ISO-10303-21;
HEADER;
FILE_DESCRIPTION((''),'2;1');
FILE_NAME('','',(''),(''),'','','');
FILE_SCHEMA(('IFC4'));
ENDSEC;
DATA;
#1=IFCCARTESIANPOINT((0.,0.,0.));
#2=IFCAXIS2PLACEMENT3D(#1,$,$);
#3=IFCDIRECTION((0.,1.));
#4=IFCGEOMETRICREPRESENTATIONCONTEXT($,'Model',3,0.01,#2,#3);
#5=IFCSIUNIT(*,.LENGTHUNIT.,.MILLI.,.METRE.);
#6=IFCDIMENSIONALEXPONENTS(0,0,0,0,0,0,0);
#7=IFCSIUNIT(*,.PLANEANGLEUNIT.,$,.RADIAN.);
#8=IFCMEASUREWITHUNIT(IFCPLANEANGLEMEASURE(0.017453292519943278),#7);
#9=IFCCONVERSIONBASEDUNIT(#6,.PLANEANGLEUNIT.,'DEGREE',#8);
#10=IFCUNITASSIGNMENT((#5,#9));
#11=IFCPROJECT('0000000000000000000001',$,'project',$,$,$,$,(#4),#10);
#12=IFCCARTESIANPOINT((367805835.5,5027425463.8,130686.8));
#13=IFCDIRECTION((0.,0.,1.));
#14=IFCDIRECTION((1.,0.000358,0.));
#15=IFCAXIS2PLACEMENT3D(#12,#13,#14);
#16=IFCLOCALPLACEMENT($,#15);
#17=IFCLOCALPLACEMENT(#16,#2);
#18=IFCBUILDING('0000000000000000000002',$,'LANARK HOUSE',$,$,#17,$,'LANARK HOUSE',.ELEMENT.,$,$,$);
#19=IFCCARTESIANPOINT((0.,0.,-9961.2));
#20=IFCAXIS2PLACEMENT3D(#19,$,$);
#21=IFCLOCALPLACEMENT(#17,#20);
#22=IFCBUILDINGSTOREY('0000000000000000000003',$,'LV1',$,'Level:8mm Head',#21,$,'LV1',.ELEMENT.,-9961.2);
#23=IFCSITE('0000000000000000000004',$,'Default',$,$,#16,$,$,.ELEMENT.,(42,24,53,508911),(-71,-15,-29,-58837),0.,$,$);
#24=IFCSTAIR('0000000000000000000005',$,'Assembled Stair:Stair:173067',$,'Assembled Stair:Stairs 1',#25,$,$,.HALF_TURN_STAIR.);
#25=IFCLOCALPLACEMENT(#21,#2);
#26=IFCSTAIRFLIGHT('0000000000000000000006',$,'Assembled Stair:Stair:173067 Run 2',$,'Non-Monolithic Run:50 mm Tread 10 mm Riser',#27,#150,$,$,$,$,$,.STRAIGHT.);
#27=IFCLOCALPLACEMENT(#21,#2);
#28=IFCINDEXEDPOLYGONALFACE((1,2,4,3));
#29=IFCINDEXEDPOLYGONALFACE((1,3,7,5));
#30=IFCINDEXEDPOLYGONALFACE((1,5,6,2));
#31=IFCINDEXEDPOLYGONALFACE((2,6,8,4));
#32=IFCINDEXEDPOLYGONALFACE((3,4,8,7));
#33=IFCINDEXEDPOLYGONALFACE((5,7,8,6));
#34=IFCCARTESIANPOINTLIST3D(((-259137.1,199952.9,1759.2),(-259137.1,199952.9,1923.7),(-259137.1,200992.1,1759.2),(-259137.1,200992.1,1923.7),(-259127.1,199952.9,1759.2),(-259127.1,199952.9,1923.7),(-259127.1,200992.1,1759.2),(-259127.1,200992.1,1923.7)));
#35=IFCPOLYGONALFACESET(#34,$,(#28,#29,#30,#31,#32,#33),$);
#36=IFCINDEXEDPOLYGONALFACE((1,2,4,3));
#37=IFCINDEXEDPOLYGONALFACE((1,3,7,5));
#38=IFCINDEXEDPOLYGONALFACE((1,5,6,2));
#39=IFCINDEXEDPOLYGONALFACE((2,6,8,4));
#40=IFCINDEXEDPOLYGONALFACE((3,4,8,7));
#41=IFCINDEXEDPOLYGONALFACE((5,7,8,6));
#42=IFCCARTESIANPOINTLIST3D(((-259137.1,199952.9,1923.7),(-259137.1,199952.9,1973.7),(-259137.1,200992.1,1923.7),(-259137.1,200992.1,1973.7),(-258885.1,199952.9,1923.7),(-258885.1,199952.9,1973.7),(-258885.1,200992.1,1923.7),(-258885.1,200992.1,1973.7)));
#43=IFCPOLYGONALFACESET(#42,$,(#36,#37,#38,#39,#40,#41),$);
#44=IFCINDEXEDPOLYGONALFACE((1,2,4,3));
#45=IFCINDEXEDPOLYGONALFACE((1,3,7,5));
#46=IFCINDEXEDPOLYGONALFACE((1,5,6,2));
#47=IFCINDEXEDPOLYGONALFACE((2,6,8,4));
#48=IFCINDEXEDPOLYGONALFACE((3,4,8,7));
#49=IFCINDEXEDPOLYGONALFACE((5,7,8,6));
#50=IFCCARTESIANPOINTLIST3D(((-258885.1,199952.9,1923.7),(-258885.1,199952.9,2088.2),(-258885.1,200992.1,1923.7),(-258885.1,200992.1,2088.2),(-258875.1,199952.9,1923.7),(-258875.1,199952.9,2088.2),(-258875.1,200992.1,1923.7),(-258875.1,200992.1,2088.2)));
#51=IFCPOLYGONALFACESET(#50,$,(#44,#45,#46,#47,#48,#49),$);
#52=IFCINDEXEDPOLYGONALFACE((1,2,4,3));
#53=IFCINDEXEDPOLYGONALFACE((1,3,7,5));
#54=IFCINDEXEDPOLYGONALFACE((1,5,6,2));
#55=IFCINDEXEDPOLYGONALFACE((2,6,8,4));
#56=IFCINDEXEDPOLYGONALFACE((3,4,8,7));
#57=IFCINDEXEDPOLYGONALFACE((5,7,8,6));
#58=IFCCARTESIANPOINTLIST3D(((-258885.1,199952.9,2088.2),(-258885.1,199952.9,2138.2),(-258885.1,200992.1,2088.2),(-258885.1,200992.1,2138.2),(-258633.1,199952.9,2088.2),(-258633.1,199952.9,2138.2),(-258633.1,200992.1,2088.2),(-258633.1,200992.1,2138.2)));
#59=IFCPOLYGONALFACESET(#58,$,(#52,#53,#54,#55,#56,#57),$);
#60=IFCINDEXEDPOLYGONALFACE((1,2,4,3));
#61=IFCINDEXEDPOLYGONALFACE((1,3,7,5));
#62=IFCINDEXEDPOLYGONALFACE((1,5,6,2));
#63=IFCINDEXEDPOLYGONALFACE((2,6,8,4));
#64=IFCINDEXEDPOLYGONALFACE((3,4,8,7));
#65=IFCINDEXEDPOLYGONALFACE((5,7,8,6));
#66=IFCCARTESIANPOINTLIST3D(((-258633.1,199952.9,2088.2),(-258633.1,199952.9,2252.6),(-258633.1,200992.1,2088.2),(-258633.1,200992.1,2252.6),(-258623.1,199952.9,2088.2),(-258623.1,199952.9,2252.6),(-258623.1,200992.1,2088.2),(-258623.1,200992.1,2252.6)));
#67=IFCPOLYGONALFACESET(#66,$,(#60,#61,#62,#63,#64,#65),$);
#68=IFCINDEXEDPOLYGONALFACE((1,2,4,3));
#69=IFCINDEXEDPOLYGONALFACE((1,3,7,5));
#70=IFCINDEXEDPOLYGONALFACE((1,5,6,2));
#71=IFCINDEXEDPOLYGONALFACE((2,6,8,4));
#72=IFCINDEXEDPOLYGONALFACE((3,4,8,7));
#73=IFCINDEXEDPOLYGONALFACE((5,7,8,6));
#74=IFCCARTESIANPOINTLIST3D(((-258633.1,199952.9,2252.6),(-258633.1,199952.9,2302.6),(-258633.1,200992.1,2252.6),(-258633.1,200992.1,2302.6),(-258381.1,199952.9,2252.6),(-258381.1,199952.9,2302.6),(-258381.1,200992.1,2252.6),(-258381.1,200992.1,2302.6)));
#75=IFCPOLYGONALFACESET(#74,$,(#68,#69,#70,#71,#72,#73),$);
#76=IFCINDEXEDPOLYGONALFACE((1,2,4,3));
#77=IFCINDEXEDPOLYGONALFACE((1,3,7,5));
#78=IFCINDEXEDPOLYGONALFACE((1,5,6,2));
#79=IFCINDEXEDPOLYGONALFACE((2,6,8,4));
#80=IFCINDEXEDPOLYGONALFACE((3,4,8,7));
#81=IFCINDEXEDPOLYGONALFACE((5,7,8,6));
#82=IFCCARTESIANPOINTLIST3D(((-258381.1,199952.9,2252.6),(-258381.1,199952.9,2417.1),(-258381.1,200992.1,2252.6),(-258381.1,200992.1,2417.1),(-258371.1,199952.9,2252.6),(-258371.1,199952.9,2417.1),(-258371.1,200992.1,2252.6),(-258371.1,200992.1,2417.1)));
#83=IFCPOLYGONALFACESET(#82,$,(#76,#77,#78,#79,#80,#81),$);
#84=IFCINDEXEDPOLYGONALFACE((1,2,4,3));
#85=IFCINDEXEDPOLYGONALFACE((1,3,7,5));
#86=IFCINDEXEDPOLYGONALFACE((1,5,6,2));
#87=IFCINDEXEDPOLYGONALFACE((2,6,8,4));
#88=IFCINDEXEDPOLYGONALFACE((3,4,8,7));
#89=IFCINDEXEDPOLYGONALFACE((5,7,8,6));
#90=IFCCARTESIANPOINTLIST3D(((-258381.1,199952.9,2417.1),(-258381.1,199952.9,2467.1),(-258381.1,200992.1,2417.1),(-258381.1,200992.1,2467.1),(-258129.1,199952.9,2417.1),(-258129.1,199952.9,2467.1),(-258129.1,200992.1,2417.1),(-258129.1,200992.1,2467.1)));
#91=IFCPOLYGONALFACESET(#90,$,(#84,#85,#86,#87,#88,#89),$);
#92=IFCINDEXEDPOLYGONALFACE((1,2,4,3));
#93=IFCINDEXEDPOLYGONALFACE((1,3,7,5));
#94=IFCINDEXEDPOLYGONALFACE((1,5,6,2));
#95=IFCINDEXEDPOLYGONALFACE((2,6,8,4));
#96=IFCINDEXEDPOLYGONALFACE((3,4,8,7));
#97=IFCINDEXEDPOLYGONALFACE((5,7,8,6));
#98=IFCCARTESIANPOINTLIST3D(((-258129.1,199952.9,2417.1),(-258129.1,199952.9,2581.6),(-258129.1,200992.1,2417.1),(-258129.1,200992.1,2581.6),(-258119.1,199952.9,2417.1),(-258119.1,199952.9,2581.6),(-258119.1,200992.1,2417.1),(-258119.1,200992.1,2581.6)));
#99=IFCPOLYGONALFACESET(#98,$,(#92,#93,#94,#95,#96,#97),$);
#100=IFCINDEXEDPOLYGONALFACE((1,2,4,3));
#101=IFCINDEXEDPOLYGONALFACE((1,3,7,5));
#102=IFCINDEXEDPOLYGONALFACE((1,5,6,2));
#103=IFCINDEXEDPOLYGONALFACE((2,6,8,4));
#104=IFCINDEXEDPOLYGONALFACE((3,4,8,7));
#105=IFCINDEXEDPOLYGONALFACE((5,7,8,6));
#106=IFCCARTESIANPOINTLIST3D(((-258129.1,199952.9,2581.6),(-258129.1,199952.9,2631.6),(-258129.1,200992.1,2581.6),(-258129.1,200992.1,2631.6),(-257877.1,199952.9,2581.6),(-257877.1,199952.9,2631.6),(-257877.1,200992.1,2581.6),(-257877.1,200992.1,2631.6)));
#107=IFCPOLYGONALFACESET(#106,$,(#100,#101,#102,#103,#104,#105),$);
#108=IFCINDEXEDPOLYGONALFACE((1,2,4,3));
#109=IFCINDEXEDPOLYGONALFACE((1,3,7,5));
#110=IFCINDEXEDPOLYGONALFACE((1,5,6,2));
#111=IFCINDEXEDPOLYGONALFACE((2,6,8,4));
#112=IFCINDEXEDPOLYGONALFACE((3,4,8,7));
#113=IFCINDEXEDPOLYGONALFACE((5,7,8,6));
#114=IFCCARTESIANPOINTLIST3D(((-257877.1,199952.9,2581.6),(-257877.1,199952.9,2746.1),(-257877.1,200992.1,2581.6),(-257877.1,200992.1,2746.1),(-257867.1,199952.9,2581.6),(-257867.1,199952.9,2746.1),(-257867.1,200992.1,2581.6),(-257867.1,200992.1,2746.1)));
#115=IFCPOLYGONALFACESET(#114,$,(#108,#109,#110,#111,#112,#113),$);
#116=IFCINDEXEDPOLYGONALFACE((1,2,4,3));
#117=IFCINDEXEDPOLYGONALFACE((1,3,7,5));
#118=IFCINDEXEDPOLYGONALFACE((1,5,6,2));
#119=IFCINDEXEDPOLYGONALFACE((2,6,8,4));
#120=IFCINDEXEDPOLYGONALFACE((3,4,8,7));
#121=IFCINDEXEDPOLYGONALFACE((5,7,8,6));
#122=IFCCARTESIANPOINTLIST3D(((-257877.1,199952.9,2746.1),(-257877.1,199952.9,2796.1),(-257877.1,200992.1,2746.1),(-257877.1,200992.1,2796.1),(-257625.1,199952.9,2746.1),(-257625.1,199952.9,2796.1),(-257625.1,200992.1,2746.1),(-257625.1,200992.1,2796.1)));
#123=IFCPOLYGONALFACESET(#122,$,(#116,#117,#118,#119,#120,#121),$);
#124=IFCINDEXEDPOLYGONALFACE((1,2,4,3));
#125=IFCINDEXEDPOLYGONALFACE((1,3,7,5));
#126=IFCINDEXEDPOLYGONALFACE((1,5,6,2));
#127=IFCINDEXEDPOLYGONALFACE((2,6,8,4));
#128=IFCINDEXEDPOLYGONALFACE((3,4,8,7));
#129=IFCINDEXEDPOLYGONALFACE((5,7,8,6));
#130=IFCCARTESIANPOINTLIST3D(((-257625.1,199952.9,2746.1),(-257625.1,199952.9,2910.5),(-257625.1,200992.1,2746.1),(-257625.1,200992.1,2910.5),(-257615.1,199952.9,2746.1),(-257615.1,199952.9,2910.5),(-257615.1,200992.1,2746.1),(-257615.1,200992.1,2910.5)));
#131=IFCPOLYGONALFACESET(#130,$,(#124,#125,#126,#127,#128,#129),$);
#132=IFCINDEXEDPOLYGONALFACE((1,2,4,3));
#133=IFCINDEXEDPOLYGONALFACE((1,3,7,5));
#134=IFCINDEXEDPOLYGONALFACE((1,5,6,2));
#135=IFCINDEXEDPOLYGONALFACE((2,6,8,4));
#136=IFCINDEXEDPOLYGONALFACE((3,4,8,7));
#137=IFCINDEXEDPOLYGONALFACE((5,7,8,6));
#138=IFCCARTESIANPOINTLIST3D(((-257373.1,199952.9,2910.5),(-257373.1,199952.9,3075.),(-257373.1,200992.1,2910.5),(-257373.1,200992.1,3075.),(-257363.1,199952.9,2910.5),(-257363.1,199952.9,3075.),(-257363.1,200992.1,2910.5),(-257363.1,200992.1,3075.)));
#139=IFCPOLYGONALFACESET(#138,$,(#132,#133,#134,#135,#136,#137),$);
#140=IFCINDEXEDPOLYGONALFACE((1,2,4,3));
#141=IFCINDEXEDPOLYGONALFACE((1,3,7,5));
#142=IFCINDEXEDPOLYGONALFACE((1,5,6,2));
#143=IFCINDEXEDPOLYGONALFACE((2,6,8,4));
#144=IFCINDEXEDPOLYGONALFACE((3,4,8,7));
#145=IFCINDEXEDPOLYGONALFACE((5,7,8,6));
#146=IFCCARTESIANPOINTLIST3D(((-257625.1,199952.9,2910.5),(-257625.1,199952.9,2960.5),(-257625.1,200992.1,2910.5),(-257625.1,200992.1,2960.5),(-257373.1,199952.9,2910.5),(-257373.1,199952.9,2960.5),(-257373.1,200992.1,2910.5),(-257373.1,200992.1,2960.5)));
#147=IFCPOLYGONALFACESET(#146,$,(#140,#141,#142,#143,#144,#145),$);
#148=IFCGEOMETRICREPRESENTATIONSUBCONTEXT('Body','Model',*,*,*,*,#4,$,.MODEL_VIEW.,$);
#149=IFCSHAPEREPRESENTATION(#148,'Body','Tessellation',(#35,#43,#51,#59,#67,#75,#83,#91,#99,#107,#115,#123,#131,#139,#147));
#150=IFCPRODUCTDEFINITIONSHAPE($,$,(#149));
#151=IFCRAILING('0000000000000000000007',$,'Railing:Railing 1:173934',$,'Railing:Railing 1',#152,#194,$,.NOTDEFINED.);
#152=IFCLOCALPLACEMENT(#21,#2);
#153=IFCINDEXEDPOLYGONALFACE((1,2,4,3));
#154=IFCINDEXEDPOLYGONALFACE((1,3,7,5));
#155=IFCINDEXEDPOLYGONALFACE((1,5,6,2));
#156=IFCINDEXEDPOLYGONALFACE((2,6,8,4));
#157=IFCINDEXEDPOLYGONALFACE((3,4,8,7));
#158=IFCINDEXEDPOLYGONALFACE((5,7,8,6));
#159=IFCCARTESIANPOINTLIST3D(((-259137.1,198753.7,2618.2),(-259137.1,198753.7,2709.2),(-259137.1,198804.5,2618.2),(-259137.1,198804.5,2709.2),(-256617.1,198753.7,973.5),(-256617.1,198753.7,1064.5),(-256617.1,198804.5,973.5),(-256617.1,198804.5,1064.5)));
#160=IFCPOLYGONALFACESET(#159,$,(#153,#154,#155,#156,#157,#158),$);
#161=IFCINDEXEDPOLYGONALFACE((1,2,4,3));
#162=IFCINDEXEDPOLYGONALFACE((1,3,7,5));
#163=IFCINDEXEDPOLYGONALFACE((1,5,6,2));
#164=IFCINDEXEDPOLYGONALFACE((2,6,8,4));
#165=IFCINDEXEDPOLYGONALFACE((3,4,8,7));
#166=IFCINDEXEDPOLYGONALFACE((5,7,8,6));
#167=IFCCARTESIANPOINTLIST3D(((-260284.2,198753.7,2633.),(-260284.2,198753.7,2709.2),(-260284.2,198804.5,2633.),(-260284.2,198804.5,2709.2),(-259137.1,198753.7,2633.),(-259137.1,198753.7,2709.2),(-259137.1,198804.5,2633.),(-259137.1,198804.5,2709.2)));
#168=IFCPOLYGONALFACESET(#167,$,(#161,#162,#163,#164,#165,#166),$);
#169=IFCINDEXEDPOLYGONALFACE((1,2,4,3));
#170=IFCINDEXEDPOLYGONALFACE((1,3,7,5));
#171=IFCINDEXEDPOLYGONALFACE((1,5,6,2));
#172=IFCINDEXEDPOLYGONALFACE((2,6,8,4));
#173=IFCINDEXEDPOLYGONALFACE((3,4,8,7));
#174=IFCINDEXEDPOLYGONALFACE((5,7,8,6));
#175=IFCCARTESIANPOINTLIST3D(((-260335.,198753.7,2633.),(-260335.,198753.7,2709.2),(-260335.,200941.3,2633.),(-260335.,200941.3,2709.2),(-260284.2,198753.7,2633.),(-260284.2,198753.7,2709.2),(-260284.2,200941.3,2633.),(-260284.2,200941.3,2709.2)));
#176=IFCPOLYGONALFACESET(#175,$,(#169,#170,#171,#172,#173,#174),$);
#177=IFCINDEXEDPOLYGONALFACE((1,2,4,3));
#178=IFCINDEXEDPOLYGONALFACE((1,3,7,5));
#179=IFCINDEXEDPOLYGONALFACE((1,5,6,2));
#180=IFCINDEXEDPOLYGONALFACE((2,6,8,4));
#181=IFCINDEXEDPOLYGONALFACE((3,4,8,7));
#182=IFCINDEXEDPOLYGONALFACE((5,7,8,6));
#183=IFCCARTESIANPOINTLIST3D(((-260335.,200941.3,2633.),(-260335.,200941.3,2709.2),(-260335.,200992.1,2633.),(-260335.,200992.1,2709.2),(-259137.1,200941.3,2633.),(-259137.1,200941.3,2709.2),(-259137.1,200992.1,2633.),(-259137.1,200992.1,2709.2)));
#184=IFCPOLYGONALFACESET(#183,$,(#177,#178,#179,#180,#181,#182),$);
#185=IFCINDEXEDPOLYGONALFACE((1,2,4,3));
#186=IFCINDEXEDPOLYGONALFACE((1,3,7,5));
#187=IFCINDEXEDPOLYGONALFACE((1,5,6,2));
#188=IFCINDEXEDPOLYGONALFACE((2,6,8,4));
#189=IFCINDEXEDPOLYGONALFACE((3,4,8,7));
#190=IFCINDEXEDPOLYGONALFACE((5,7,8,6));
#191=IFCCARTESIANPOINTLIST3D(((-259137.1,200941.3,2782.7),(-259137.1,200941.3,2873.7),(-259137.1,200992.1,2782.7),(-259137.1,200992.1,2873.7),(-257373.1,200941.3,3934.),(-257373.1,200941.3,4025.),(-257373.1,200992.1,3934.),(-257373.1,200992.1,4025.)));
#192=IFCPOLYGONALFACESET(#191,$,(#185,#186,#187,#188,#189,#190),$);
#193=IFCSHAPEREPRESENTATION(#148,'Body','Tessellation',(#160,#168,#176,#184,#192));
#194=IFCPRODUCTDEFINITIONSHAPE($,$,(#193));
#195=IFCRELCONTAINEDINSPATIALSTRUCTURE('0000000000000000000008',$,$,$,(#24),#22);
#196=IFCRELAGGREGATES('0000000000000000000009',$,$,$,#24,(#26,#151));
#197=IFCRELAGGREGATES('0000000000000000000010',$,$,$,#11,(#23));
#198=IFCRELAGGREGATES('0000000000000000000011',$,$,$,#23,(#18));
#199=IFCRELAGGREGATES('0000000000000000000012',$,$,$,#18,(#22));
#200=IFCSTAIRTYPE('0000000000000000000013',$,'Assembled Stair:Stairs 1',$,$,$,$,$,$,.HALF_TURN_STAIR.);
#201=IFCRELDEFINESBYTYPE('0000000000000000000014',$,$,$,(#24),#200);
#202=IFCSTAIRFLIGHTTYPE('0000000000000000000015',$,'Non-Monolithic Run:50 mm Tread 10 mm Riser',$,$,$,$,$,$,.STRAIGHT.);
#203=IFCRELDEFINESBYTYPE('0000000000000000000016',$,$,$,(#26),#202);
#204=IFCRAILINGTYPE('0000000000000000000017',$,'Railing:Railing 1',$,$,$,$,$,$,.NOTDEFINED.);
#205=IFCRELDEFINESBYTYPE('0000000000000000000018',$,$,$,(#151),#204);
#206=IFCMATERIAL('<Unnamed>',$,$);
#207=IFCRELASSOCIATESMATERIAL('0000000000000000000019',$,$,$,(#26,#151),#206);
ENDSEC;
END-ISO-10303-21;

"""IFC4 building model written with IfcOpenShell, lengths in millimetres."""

from ifc_helpers import new_model, entity, si_unit, converted_unit, direction, frame, origin, place, context, subcontext, project, spatial, indexed_curve, outline, extrude, material, type_object, element, aggregate, save


model = new_model("IFC4")

# Units and contexts
model_context = context("Model", 3, precision=0.01, world=origin(), true_north=direction((0.0, 1.0)))
body_context = subcontext(model_context, "Body", "Model", "MODEL_VIEW")
ifc_project = project(units=[si_unit("LENGTHUNIT", "METRE", prefix="MILLI"), converted_unit("PLANEANGLEUNIT", "DEGREE", entity("IfcPlaneAngleMeasure", 0.017453292519943278), si_unit("PLANEANGLEUNIT", "RADIAN"), dimensions=[0, 0, 0, 0, 0, 0, 0])], contexts=[model_context])

# Site, building, storey
site_placement = place(None, frame((367805835.5, 5027425463.8, 130686.8), z_axis=(0.0, 0.0, 1.0), x_axis=(1.0, 0.000358, 0.0)))
site = spatial("IfcSite", under=ifc_project, at=site_placement, Name="Default", CompositionType="ELEMENT", RefLatitude=(42, 24, 53, 508911), RefLongitude=(-71, -15, -29, -58837), RefElevation=0.0)
building_placement = place(site_placement, origin())
building = spatial("IfcBuilding", under=site, at=building_placement, Name="LANARK HOUSE", LongName="LANARK HOUSE", CompositionType="ELEMENT")
storey_placement = place(building_placement, frame((0.0, 0.0, -9961.2)))
storey = spatial("IfcBuildingStorey", under=building, at=storey_placement, Name="LV1", ObjectType="Level:8mm Head", LongName="LV1", CompositionType="ELEMENT", Elevation=-9961.2)

# Stair
stair_type = type_object("IfcStairType", Name="Assembled Stair:Stairs 1", PredefinedType="HALF_TURN_STAIR")
stair_placement = place(storey_placement, origin())
stair = element("IfcStair", 1, at=stair_placement, inside=storey, type_object=stair_type, Name="Assembled Stair:Stair:173067", ObjectType="Assembled Stair:Stairs 1", PredefinedType="HALF_TURN_STAIR")
ifc_material_1 = material(Name="<Unnamed>")

# Stair flight
stair_flight_type = type_object("IfcStairFlightType", Name="Non-Monolithic Run:50 mm Tread 10 mm Riser", PredefinedType="STRAIGHT")
stair_flight_1_placement = place(stair_placement, frame((-259137.1, 199952.9, 0.0)))
stair_flight_1 = element("IfcStairFlight", 2, at=stair_flight_1_placement, type_object=stair_flight_type, material=ifc_material_1, Name="Assembled Stair:Stair:173067 Run 2", ObjectType="Non-Monolithic Run:50 mm Tread 10 mm Riser", PredefinedType="STRAIGHT", context=body_context, shape_type="SweptSolid", body=[
    extrude(outline(indexed_curve([(-519.6, -5.0), (519.6, -5.0), (519.6, 5.0), (-519.6, 5.0), (-519.6, -5.0)], self_intersect=False)), frame((5.0, 519.6, 1759.2), z_axis=(0.0, 0.0, 1.0), x_axis=(0.0, 1.0, 0.0)), (0.0, 0.0, 1.0), 164.5),
    extrude(outline(indexed_curve([(-126.0, -519.6), (126.0, -519.6), (126.0, 519.6), (-126.0, 519.6), (-126.0, -519.6)], self_intersect=False)), frame((126.0, 519.6, 1923.7), z_axis=(0.0, 0.0, 1.0), x_axis=(-1.0, 0.0, 0.0)), (0.0, 0.0, 1.0), 50.0),
    extrude(outline(indexed_curve([(-519.6, -5.0), (519.6, -5.0), (519.6, 5.0), (-519.6, 5.0), (-519.6, -5.0)], self_intersect=False)), frame((257.0, 519.6, 1923.7), z_axis=(0.0, 0.0, 1.0), x_axis=(0.0, 1.0, 0.0)), (0.0, 0.0, 1.0), 164.5),
    extrude(outline(indexed_curve([(-126.0, -519.6), (126.0, -519.6), (126.0, 519.6), (-126.0, 519.6), (-126.0, -519.6)], self_intersect=False)), frame((378.0, 519.6, 2088.2), z_axis=(0.0, 0.0, 1.0), x_axis=(-1.0, 0.0, 0.0)), (0.0, 0.0, 1.0), 50.0),
    extrude(outline(indexed_curve([(-519.6, -5.0), (519.6, -5.0), (519.6, 5.0), (-519.6, 5.0), (-519.6, -5.0)], self_intersect=False)), frame((509.0, 519.6, 2088.2), z_axis=(0.0, 0.0, 1.0), x_axis=(0.0, 1.0, 0.0)), (0.0, 0.0, 1.0), 164.5),
    extrude(outline(indexed_curve([(-126.0, -519.6), (126.0, -519.6), (126.0, 519.6), (-126.0, 519.6), (-126.0, -519.6)], self_intersect=False)), frame((630.0, 519.6, 2252.6), z_axis=(0.0, 0.0, 1.0), x_axis=(-1.0, 0.0, 0.0)), (0.0, 0.0, 1.0), 50.0),
    extrude(outline(indexed_curve([(-519.6, -5.0), (519.6, -5.0), (519.6, 5.0), (-519.6, 5.0), (-519.6, -5.0)], self_intersect=False)), frame((761.0, 519.6, 2252.6), z_axis=(0.0, 0.0, 1.0), x_axis=(0.0, 1.0, 0.0)), (0.0, 0.0, 1.0), 164.5),
    extrude(outline(indexed_curve([(-126.0, -519.6), (126.0, -519.6), (126.0, 519.6), (-126.0, 519.6), (-126.0, -519.6)], self_intersect=False)), frame((882.0, 519.6, 2417.1), z_axis=(0.0, 0.0, 1.0), x_axis=(-1.0, 0.0, 0.0)), (0.0, 0.0, 1.0), 50.0),
    extrude(outline(indexed_curve([(-519.6, -5.0), (519.6, -5.0), (519.6, 5.0), (-519.6, 5.0), (-519.6, -5.0)], self_intersect=False)), frame((1013.0, 519.6, 2417.1), z_axis=(0.0, 0.0, 1.0), x_axis=(0.0, 1.0, 0.0)), (0.0, 0.0, 1.0), 164.5),
    extrude(outline(indexed_curve([(-126.0, -519.6), (126.0, -519.6), (126.0, 519.6), (-126.0, 519.6), (-126.0, -519.6)], self_intersect=False)), frame((1134.0, 519.6, 2581.6), z_axis=(0.0, 0.0, 1.0), x_axis=(-1.0, 0.0, 0.0)), (0.0, 0.0, 1.0), 50.0),
    extrude(outline(indexed_curve([(-519.6, -5.0), (519.6, -5.0), (519.6, 5.0), (-519.6, 5.0), (-519.6, -5.0)], self_intersect=False)), frame((1265.0, 519.6, 2581.6), z_axis=(0.0, 0.0, 1.0), x_axis=(0.0, 1.0, 0.0)), (0.0, 0.0, 1.0), 164.5),
    extrude(outline(indexed_curve([(-126.0, -519.6), (126.0, -519.6), (126.0, 519.6), (-126.0, 519.6), (-126.0, -519.6)], self_intersect=False)), frame((1386.0, 519.6, 2746.1), z_axis=(0.0, 0.0, 1.0), x_axis=(-1.0, 0.0, 0.0)), (0.0, 0.0, 1.0), 50.0),
    extrude(outline(indexed_curve([(-519.6, -5.0), (519.6, -5.0), (519.6, 5.0), (-519.6, 5.0), (-519.6, -5.0)], self_intersect=False)), frame((1517.0, 519.6, 2746.1), z_axis=(0.0, 0.0, 1.0), x_axis=(0.0, 1.0, 0.0)), (0.0, 0.0, 1.0), 164.5),
    extrude(outline(indexed_curve([(-519.6, -5.0), (519.6, -5.0), (519.6, 5.0), (-519.6, 5.0), (-519.6, -5.0)], self_intersect=False)), frame((1769.0, 519.6, 2910.5), z_axis=(0.0, 0.0, 1.0), x_axis=(0.0, 1.0, 0.0)), (0.0, 0.0, 1.0), 164.5),
    extrude(outline(indexed_curve([(-126.0, -519.6), (126.0, -519.6), (126.0, 519.6), (-126.0, 519.6), (-126.0, -519.6)], self_intersect=False)), frame((1638.0, 519.6, 2910.5), z_axis=(0.0, 0.0, 1.0), x_axis=(-1.0, 0.0, 0.0)), (0.0, 0.0, 1.0), 50.0),
])

# Railing
railing_type = type_object("IfcRailingType", Name="Railing:Railing 1", PredefinedType="NOTDEFINED")
railing_placement = place(stair_placement, frame((-260335.0, 198753.7, 973.5)))
railing = element("IfcRailing", 3, at=railing_placement, type_object=railing_type, material=ifc_material_1, Name="Railing:Railing 1:173934", ObjectType="Railing:Railing 1", PredefinedType="NOTDEFINED", context=body_context, shape_type="SweptSolid", body=[
    extrude(outline(indexed_curve([(-1529.5, -38.1), (1479.8, -38.1), (1529.5, 38.1), (-1479.8, 38.1), (-1529.5, -38.1)], self_intersect=False)), frame((2457.9, 0.0, 867.9), z_axis=(0.0, 1.0, 0.0), x_axis=(-0.837419, 0.0, 0.546561)), (0.0, 0.0, 1.0), 50.8),
    extrude(outline(indexed_curve([(-573.6, -25.4), (573.6, -25.4), (573.6, 25.4), (-573.6, 25.4), (-573.6, -25.4)], self_intersect=False)), frame((624.4, 25.4, 1659.5), z_axis=(0.0, 0.0, 1.0), x_axis=(-1.0, 0.0, 0.0)), (0.0, 0.0, 1.0), 76.2),
    extrude(outline(indexed_curve([(-1093.8, -25.4), (1093.8, -25.4), (1093.8, 25.4), (-1093.8, 25.4), (-1093.8, -25.4)], self_intersect=False)), frame((25.4, 1093.8, 1659.5), z_axis=(0.0, 0.0, 1.0), x_axis=(0.0, 1.0, 0.0)), (0.0, 0.0, 1.0), 76.2),
    extrude(outline(indexed_curve([(-599.0, -25.4), (599.0, -25.4), (599.0, 25.4), (-599.0, 25.4), (-599.0, -25.4)], self_intersect=False)), frame((599.0, 2213.0, 1659.5)), (0.0, 0.0, 1.0), 76.2),
    extrude(outline(indexed_curve([(-1028.4, -38.1), (1078.1, -38.1), (1028.4, 38.1), (-1078.1, 38.1), (-1028.4, -38.1)], self_intersect=False)), frame((2079.9, 2187.6, 2430.4), z_axis=(0.0, 1.0, 0.0), x_axis=(0.837419, 0.0, 0.546561)), (0.0, 0.0, 1.0), 50.8),
])
aggregate(stair, [stair_flight_1, railing])

save(model, "model.ifc")
